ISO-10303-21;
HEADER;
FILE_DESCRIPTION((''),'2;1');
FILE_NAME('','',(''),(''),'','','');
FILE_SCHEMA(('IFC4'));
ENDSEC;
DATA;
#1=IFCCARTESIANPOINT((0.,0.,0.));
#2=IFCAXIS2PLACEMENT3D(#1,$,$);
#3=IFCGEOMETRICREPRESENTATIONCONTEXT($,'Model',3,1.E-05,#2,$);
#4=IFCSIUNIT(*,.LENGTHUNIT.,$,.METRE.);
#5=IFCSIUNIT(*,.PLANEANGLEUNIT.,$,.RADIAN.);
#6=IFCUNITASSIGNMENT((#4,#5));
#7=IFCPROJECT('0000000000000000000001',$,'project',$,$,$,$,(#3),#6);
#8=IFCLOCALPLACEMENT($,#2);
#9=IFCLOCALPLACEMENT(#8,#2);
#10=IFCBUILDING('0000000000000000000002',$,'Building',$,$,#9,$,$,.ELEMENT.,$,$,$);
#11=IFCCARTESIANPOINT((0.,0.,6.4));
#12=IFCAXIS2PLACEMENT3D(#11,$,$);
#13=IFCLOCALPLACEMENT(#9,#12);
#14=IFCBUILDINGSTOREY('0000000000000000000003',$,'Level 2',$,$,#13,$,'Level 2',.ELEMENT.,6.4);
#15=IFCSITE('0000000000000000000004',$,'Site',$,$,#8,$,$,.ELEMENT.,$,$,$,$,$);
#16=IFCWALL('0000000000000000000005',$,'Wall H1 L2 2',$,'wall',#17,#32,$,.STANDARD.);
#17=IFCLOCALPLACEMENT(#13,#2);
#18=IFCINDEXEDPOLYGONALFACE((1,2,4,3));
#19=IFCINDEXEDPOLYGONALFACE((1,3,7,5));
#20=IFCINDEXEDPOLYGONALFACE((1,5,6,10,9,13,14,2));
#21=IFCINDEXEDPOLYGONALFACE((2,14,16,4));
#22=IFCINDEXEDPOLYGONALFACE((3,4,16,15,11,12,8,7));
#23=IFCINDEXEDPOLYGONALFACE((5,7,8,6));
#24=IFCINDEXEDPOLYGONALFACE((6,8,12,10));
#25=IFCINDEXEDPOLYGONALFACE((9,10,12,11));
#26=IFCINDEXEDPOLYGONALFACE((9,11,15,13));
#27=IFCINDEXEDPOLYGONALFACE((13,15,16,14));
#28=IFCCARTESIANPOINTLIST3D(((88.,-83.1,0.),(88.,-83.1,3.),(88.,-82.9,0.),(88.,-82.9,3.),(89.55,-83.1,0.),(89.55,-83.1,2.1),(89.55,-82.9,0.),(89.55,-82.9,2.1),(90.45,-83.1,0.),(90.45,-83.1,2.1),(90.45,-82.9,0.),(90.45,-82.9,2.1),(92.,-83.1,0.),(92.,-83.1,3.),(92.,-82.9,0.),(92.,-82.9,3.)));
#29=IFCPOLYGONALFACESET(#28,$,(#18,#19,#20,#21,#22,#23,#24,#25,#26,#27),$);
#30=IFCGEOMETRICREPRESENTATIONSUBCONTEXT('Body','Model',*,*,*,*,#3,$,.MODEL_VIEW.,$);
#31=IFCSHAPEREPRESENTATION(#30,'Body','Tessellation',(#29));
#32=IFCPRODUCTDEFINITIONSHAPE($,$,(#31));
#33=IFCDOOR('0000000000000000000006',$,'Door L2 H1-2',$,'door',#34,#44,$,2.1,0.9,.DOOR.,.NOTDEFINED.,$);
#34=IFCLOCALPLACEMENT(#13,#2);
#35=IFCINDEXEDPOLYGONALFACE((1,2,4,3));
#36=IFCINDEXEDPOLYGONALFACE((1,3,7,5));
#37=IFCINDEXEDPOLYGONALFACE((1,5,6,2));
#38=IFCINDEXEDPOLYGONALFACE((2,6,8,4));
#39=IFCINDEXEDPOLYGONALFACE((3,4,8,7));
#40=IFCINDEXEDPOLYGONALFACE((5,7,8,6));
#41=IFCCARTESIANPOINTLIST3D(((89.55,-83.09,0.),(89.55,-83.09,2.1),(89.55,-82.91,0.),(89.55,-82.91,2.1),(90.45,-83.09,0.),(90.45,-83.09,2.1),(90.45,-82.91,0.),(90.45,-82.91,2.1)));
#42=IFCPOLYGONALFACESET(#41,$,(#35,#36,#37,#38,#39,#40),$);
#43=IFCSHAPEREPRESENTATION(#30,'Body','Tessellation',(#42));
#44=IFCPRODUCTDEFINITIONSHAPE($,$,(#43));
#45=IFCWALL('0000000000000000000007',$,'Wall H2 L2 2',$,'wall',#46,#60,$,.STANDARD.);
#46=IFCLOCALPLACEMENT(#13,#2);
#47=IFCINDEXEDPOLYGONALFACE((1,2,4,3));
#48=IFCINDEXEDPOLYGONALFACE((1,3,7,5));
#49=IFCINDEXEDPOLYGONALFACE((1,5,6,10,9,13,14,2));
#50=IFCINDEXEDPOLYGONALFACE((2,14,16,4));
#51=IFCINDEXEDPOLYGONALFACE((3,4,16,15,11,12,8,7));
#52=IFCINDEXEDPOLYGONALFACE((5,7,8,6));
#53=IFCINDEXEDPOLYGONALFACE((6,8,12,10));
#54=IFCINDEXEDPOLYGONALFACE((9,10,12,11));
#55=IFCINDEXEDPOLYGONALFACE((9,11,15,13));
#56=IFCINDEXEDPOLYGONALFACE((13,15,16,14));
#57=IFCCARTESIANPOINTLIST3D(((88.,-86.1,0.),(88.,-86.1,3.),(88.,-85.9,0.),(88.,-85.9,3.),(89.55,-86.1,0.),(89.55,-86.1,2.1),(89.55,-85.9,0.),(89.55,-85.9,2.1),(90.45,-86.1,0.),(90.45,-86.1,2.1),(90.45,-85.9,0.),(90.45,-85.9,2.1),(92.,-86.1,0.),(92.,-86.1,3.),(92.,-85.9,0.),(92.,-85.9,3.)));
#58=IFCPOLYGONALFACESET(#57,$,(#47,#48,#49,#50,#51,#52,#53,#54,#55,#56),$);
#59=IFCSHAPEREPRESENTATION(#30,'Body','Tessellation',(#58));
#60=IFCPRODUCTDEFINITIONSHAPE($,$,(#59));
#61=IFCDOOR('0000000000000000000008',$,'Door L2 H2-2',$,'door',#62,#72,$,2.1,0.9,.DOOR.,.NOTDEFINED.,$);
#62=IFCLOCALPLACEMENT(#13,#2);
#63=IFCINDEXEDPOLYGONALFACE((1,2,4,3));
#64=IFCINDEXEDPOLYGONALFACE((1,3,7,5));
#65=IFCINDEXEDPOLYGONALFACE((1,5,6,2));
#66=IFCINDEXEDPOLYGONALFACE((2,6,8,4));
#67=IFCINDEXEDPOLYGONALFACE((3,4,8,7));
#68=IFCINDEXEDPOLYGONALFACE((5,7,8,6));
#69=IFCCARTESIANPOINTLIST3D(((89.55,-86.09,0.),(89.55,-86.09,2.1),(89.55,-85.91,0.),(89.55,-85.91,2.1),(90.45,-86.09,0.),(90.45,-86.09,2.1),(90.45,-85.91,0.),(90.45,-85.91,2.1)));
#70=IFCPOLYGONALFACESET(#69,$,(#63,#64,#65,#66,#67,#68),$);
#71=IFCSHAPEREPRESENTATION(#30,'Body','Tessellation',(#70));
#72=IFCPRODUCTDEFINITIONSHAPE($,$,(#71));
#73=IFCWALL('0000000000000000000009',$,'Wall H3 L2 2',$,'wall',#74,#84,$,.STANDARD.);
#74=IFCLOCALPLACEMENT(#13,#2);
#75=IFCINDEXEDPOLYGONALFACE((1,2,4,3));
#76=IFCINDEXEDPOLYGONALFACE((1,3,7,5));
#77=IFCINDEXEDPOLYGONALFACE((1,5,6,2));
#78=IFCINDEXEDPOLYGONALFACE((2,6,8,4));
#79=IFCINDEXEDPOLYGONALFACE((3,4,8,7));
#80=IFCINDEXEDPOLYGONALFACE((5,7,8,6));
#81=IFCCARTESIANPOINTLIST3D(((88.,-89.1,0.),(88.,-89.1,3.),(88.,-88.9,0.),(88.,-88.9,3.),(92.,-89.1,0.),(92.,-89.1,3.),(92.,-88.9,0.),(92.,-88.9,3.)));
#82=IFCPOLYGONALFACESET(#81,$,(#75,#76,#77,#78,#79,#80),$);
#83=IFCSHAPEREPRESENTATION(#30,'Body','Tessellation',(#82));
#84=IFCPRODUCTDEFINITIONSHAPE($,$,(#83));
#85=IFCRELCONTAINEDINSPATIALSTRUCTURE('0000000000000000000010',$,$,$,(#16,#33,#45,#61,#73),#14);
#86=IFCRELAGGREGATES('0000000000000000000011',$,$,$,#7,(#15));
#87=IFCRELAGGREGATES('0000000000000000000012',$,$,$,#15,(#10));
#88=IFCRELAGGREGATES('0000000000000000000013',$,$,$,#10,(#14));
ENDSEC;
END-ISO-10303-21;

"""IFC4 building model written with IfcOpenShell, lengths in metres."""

from ifc_helpers import new_model, si_unit, frame, frame_2d, origin, origin_2d, place, context, subcontext, project, spatial, rectangle, extrude, element, fill, save


model = new_model("IFC4")

# Units and contexts
model_context = context("Model", 3, precision=1e-05, world=origin())
body_context = subcontext(model_context, "Body", "Model", "MODEL_VIEW")
ifc_project = project(units=[si_unit("LENGTHUNIT", "METRE"), si_unit("PLANEANGLEUNIT", "RADIAN")], contexts=[model_context])

# Site, building, storey
site_placement = place(None, origin())
site = spatial("IfcSite", under=ifc_project, at=site_placement, Name="Site", CompositionType="ELEMENT")
building_placement = place(site_placement, origin())
building = spatial("IfcBuilding", under=site, at=building_placement, Name="Building", CompositionType="ELEMENT")
storey_placement = place(building_placement, frame((0.0, 0.0, 6.4)))
storey = spatial("IfcBuildingStorey", under=building, at=storey_placement, Name="Level 2", LongName="Level 2", CompositionType="ELEMENT", Elevation=6.4)

# Walls, openings, doors
wall_1_placement = place(storey_placement, frame((88.0, -83.0, 0.0), z_axis=(0.0, 0.0, 1.0), x_axis=(1.0, 0.0, 0.0)))
wall_1 = element("IfcWall", 1, at=wall_1_placement, inside=storey, Name="Wall H1 L2 2", ObjectType="wall", PredefinedType="STANDARD", context=body_context, shape_type="SweptSolid", body=[
    extrude(rectangle(XDim=4.0, YDim=0.2, at=frame_2d((2.0, 0.0))), origin(), (0.0, 0.0, 1.0), 3.0),
])
opening_1_placement = place(storey_placement, frame((90.0, -83.0, 0.0), z_axis=(0.0, 0.0, 1.0), x_axis=(1.0, 0.0, 0.0)))
opening_1 = element("IfcOpeningElement", 2, at=opening_1_placement, cuts=wall_1, ObjectType="Opening", PredefinedType="OPENING", context=body_context, shape_type="SweptSolid", body=[
    extrude(rectangle(XDim=0.9, YDim=0.22, at=origin_2d()), origin(), (0.0, 0.0, 1.0), 2.1),
])
door_1_placement = place(storey_placement, frame((90.0, -83.0, 0.0), z_axis=(0.0, 0.0, 1.0), x_axis=(1.0, 0.0, 0.0)))
door_1 = element("IfcDoor", 3, at=door_1_placement, inside=storey, Name="Door L2 H1-2", ObjectType="door", OperationType="NOTDEFINED", OverallHeight=2.1, OverallWidth=0.9, PredefinedType="DOOR", context=body_context, shape_type="SweptSolid", body=[
    extrude(rectangle(XDim=0.9, YDim=0.18, at=origin_2d()), origin(), (0.0, 0.0, 1.0), 2.1),
])
fill(opening_1, door_1)
wall_2_placement = place(storey_placement, frame((88.0, -86.0, 0.0), z_axis=(0.0, 0.0, 1.0), x_axis=(1.0, 0.0, 0.0)))
wall_2 = element("IfcWall", 4, at=wall_2_placement, inside=storey, Name="Wall H2 L2 2", ObjectType="wall", PredefinedType="STANDARD", context=body_context, shape_type="SweptSolid", body=[
    extrude(rectangle(XDim=4.0, YDim=0.2, at=frame_2d((2.0, 0.0))), origin(), (0.0, 0.0, 1.0), 3.0),
])
opening_2_placement = place(storey_placement, frame((90.0, -86.0, 0.0), z_axis=(0.0, 0.0, 1.0), x_axis=(1.0, 0.0, 0.0)))
opening_2 = element("IfcOpeningElement", 5, at=opening_2_placement, cuts=wall_2, ObjectType="Opening", PredefinedType="OPENING", context=body_context, shape_type="SweptSolid", body=[
    extrude(rectangle(XDim=0.9, YDim=0.22, at=origin_2d()), origin(), (0.0, 0.0, 1.0), 2.1),
])
door_2_placement = place(storey_placement, frame((90.0, -86.0, 0.0), z_axis=(0.0, 0.0, 1.0), x_axis=(1.0, 0.0, 0.0)))
door_2 = element("IfcDoor", 6, at=door_2_placement, inside=storey, Name="Door L2 H2-2", ObjectType="door", OperationType="NOTDEFINED", OverallHeight=2.1, OverallWidth=0.9, PredefinedType="DOOR", context=body_context, shape_type="SweptSolid", body=[
    extrude(rectangle(XDim=0.9, YDim=0.18, at=origin_2d()), origin(), (0.0, 0.0, 1.0), 2.1),
])
fill(opening_2, door_2)

# Wall
wall_3_placement = place(storey_placement, frame((88.0, -89.0, 0.0), z_axis=(0.0, 0.0, 1.0), x_axis=(1.0, 0.0, 0.0)))
element("IfcWall", 7, at=wall_3_placement, inside=storey, Name="Wall H3 L2 2", ObjectType="wall", PredefinedType="STANDARD", context=body_context, shape_type="SweptSolid", body=[
    extrude(rectangle(XDim=4.0, YDim=0.2, at=frame_2d((2.0, 0.0))), origin(), (0.0, 0.0, 1.0), 3.0),
])

save(model, "model.ifc")
